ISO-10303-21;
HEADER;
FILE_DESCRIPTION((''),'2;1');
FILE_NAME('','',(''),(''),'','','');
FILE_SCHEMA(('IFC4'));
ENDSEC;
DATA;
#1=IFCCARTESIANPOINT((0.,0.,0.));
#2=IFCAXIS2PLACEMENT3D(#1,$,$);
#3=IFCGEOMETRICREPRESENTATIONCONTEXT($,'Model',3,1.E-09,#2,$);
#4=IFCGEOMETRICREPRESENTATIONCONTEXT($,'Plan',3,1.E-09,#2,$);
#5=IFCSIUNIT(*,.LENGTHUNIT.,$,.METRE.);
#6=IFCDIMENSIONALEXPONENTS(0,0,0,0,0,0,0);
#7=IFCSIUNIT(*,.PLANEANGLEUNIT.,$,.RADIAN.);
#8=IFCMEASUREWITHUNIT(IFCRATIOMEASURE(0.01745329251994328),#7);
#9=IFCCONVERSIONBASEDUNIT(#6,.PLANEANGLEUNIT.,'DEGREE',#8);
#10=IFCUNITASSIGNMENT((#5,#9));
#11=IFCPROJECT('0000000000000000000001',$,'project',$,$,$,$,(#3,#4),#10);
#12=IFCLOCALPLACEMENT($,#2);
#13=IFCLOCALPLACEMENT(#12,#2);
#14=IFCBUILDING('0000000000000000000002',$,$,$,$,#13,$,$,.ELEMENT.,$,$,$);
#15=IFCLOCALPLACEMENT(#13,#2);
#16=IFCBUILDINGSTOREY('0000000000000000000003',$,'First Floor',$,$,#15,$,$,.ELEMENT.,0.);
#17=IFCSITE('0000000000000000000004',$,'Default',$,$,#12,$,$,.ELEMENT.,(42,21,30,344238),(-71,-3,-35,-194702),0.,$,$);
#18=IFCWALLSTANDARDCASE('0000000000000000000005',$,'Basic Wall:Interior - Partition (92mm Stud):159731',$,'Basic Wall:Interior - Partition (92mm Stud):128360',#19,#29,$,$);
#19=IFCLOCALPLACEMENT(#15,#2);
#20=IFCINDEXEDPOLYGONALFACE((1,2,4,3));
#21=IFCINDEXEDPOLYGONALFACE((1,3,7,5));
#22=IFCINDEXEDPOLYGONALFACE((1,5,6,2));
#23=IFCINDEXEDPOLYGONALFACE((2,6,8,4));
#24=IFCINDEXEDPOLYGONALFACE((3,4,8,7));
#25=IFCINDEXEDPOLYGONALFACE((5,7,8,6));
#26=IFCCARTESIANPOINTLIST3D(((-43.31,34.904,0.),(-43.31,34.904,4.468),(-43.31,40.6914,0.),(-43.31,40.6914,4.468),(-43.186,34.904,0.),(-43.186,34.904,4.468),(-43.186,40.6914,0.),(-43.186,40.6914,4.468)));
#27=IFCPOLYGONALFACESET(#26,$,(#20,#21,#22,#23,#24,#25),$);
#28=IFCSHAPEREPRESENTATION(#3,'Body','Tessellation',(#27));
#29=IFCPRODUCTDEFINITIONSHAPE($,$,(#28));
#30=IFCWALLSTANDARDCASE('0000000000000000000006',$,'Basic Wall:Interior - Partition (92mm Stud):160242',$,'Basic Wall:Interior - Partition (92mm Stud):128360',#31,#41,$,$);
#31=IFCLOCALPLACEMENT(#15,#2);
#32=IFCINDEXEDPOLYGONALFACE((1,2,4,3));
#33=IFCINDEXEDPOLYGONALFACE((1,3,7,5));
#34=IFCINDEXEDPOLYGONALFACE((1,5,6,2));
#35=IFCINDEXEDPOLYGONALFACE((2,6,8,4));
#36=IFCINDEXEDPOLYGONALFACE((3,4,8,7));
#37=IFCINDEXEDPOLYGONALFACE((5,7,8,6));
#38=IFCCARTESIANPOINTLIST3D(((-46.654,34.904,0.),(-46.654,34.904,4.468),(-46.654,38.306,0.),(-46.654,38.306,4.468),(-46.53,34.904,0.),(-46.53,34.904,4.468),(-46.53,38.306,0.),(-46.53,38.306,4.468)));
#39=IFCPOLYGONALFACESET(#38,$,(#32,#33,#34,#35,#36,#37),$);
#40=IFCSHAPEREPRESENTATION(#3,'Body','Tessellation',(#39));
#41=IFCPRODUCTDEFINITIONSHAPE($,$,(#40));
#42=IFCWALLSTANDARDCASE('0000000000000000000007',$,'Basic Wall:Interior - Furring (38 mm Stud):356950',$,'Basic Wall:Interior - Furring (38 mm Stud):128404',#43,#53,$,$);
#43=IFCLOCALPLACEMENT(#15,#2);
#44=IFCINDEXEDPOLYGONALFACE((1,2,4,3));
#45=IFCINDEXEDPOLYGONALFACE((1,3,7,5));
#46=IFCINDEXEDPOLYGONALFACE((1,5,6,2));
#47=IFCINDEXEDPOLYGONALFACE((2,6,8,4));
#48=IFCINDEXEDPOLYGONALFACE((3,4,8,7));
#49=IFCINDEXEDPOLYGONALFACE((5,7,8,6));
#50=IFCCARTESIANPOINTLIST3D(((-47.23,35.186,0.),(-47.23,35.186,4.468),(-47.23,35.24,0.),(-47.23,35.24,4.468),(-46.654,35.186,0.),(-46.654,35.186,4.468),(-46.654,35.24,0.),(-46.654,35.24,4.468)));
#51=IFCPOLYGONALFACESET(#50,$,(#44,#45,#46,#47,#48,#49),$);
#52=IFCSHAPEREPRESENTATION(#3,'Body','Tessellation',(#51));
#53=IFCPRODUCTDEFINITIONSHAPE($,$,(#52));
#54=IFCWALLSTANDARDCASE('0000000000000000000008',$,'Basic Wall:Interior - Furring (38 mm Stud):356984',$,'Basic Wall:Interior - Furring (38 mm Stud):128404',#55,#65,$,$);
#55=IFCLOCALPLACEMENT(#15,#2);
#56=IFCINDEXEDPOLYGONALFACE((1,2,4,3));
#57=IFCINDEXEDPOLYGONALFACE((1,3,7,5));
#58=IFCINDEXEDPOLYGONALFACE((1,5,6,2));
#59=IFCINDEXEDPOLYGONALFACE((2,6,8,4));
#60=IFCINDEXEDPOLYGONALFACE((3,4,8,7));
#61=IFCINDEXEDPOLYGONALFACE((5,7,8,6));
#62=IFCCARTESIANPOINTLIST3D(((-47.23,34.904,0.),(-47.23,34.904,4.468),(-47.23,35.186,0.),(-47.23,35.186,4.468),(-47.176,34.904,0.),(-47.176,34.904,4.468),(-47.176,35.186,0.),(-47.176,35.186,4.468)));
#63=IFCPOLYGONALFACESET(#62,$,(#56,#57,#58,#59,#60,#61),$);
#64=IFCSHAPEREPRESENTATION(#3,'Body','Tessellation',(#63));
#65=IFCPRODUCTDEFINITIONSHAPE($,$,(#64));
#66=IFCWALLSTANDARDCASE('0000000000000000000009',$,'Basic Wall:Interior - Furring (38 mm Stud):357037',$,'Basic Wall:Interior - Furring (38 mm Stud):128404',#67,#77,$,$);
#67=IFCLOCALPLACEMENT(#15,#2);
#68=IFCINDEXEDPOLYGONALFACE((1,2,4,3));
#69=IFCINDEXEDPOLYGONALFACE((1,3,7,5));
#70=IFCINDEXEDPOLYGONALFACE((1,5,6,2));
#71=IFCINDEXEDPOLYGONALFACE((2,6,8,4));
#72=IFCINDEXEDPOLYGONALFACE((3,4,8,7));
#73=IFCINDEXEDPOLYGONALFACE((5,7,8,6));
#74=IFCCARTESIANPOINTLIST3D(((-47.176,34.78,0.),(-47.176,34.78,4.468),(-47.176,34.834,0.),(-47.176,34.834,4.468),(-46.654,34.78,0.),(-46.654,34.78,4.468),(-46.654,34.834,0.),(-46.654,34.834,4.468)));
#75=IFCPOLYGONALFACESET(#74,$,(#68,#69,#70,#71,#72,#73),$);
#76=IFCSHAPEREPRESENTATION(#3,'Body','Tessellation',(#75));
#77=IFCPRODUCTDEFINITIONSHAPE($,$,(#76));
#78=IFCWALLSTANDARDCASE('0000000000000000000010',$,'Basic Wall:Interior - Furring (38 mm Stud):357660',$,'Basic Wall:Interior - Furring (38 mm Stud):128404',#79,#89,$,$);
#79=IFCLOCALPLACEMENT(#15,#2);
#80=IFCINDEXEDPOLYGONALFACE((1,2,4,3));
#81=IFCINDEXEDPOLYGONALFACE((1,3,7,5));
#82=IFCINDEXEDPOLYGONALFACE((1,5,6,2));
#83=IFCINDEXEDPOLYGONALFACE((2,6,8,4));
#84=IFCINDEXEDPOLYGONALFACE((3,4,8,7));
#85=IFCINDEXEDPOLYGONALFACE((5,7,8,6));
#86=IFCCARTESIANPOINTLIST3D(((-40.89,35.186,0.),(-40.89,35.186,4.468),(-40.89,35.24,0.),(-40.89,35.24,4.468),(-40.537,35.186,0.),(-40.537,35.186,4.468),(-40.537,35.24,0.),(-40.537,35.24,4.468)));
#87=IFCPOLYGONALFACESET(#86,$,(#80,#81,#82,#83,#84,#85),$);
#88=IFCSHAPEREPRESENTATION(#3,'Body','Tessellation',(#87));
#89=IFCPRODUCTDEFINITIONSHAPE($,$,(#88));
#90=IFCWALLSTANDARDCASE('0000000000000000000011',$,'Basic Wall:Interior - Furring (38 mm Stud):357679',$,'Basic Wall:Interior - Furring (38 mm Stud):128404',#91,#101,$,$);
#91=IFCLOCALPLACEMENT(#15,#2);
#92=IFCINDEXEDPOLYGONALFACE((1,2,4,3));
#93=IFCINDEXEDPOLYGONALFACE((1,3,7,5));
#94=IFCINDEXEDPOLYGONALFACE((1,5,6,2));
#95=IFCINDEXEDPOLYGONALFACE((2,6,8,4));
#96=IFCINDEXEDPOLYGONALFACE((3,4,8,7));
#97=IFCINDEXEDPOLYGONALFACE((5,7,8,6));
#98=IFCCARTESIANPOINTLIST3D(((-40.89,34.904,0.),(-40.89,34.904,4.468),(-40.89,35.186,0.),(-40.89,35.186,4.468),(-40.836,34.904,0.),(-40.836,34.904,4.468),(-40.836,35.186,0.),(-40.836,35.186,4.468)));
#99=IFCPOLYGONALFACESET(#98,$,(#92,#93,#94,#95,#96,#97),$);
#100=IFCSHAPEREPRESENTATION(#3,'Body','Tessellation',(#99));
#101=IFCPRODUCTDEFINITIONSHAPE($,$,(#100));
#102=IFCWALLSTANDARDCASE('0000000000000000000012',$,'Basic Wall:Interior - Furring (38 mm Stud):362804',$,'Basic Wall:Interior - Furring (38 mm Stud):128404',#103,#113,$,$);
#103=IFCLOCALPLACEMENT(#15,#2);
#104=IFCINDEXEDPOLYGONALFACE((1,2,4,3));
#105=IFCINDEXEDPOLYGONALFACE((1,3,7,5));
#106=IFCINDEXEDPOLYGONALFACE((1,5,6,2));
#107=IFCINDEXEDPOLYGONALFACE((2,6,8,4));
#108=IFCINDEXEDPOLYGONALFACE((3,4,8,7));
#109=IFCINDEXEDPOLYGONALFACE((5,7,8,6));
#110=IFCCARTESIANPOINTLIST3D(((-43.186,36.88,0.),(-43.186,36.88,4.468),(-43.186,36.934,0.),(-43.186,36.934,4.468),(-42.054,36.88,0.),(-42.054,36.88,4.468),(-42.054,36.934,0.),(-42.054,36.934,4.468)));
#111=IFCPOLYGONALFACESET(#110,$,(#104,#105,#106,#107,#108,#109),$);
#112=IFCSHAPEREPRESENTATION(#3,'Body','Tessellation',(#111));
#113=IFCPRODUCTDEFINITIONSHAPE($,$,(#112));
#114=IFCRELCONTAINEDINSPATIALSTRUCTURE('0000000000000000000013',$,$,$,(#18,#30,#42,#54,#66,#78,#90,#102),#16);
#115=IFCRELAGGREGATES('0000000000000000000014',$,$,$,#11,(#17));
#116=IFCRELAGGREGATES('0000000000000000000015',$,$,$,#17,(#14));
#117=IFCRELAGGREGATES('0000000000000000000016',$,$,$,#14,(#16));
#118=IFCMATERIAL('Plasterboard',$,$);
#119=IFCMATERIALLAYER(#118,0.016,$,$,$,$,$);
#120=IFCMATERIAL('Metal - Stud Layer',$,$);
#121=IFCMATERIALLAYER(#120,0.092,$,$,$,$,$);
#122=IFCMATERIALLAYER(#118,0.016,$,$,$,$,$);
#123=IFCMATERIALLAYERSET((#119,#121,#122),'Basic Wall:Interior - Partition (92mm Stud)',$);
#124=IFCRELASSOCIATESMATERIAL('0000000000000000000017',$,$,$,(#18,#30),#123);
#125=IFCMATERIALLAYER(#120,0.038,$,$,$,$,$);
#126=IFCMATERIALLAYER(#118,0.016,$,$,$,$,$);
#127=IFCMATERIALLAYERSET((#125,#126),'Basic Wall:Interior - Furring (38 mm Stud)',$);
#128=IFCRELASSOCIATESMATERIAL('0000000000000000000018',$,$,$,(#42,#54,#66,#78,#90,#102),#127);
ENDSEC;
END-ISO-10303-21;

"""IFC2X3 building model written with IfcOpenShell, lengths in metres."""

from ifc_helpers import new_model, entity, si_unit, converted_unit, frame, frame_2d, origin, place, context, project, spatial, rectangle, extrude, material, layer, layer_set, layer_usage, element, save


model = new_model("IFC2X3")

# Units and contexts
model_context = context("Model", 3, precision=1e-09, world=origin())
plan_context = context("Plan", 3, precision=1e-09, world=origin())
ifc_project = project(units=[si_unit("LENGTHUNIT", "METRE"), converted_unit("PLANEANGLEUNIT", "DEGREE", entity("IfcRatioMeasure", 0.01745329251994328), si_unit("PLANEANGLEUNIT", "RADIAN"), dimensions=[0, 0, 0, 0, 0, 0, 0])], contexts=[model_context, plan_context])

# Site, building, storey
site_placement = place(None, origin())
site = spatial("IfcSite", under=ifc_project, at=site_placement, Name="Default", CompositionType="ELEMENT", RefLatitude=(42, 21, 30, 344238), RefLongitude=(-71, -3, -35, -194702), RefElevation=0.0)
building_placement = place(site_placement, origin())
building = spatial("IfcBuilding", under=site, at=building_placement, CompositionType="ELEMENT")
storey_placement = place(building_placement, origin())
storey = spatial("IfcBuildingStorey", under=building, at=storey_placement, Name="First Floor", CompositionType="ELEMENT", Elevation=0.0)

# Shared definitions
ifc_material_1 = material(Name="Plasterboard")
ifc_layer_1 = layer(ifc_material_1, 0.016)
ifc_material_2 = material(Name="Metal - Stud Layer")
ifc_layer_2 = layer(ifc_material_2, 0.092)
ifc_layer_3 = layer(ifc_material_1, 0.016)
ifc_layer_set_1 = layer_set([ifc_layer_1, ifc_layer_2, ifc_layer_3], Name="Basic Wall:Interior - Partition (92mm Stud)")

# Walls
ifc_layer_4 = layer(ifc_material_2, 0.038)
ifc_layer_5 = layer(ifc_material_1, 0.016)
ifc_layer_set_2 = layer_set([ifc_layer_4, ifc_layer_5], Name="Basic Wall:Interior - Furring (38 mm Stud)")
ifc_layer_usage_1 = layer_usage(ifc_layer_set_1, "AXIS2", "NEGATIVE", 0.062)
wall_1_placement = place(storey_placement, frame((-43.248, 34.904, 0.0), z_axis=(0.0, 0.0, 1.0), x_axis=(0.0, 1.0, 0.0)))
element("IfcWallStandardCase", 1, at=wall_1_placement, inside=storey, material=ifc_layer_usage_1, Name="Basic Wall:Interior - Partition (92mm Stud):159731", ObjectType="Basic Wall:Interior - Partition (92mm Stud):128360", context=model_context, shape_type="SweptSolid", body=[
    extrude(rectangle(XDim=5.7874, YDim=0.124, at=frame_2d((2.8937, 0.0), x_axis=(-1.0, 0.0))), origin(), (0.0, 0.0, 1.0), 4.468),
])
ifc_layer_usage_2 = layer_usage(ifc_layer_set_1, "AXIS2", "NEGATIVE", 0.062)
wall_2_placement = place(storey_placement, frame((-46.592, 38.306, 0.0), z_axis=(0.0, 0.0, 1.0), x_axis=(0.0, -1.0, 0.0)))
element("IfcWallStandardCase", 2, at=wall_2_placement, inside=storey, material=ifc_layer_usage_2, Name="Basic Wall:Interior - Partition (92mm Stud):160242", ObjectType="Basic Wall:Interior - Partition (92mm Stud):128360", context=model_context, shape_type="SweptSolid", body=[
    extrude(rectangle(XDim=3.402, YDim=0.124, at=frame_2d((1.701, 0.0), x_axis=(-1.0, 0.0))), origin(), (0.0, 0.0, 1.0), 4.468),
])
ifc_layer_usage_3 = layer_usage(ifc_layer_set_2, "AXIS2", "NEGATIVE", 0.027)
wall_3_placement = place(storey_placement, frame((-46.654, 35.213, 0.0), z_axis=(0.0, 0.0, 1.0), x_axis=(-1.0, 0.0, 0.0)))
element("IfcWallStandardCase", 3, at=wall_3_placement, inside=storey, material=ifc_layer_usage_3, Name="Basic Wall:Interior - Furring (38 mm Stud):356950", ObjectType="Basic Wall:Interior - Furring (38 mm Stud):128404", context=model_context, shape_type="SweptSolid", body=[
    extrude(rectangle(XDim=0.576, YDim=0.054, at=frame_2d((0.288, 0.0), x_axis=(-1.0, 0.0))), origin(), (0.0, 0.0, 1.0), 4.468),
])
ifc_layer_usage_4 = layer_usage(ifc_layer_set_2, "AXIS2", "NEGATIVE", 0.027)
wall_4_placement = place(storey_placement, frame((-47.203, 35.186, 0.0), z_axis=(0.0, 0.0, 1.0), x_axis=(0.0, -1.0, 0.0)))
element("IfcWallStandardCase", 4, at=wall_4_placement, inside=storey, material=ifc_layer_usage_4, Name="Basic Wall:Interior - Furring (38 mm Stud):356984", ObjectType="Basic Wall:Interior - Furring (38 mm Stud):128404", context=model_context, shape_type="SweptSolid", body=[
    extrude(rectangle(XDim=0.282, YDim=0.054, at=frame_2d((0.141, 0.0), x_axis=(-1.0, 0.0))), origin(), (0.0, 0.0, 1.0), 4.468),
])
ifc_layer_usage_5 = layer_usage(ifc_layer_set_2, "AXIS2", "NEGATIVE", 0.027)
wall_5_placement = place(storey_placement, frame((-47.176, 34.807, 0.0)))
element("IfcWallStandardCase", 5, at=wall_5_placement, inside=storey, material=ifc_layer_usage_5, Name="Basic Wall:Interior - Furring (38 mm Stud):357037", ObjectType="Basic Wall:Interior - Furring (38 mm Stud):128404", context=model_context, shape_type="SweptSolid", body=[
    extrude(rectangle(XDim=0.522, YDim=0.054, at=frame_2d((0.261, 0.0), x_axis=(-1.0, 0.0))), origin(), (0.0, 0.0, 1.0), 4.468),
])
ifc_layer_usage_6 = layer_usage(ifc_layer_set_2, "AXIS2", "NEGATIVE", 0.027)
wall_6_placement = place(storey_placement, frame((-40.537, 35.213, 0.0), z_axis=(0.0, 0.0, 1.0), x_axis=(-1.0, 0.0, 0.0)))
element("IfcWallStandardCase", 6, at=wall_6_placement, inside=storey, material=ifc_layer_usage_6, Name="Basic Wall:Interior - Furring (38 mm Stud):357660", ObjectType="Basic Wall:Interior - Furring (38 mm Stud):128404", context=model_context, shape_type="SweptSolid", body=[
    extrude(rectangle(XDim=0.353, YDim=0.054, at=frame_2d((0.1765, 0.0), x_axis=(-1.0, 0.0))), origin(), (0.0, 0.0, 1.0), 4.468),
])
ifc_layer_usage_7 = layer_usage(ifc_layer_set_2, "AXIS2", "NEGATIVE", 0.027)
wall_7_placement = place(storey_placement, frame((-40.863, 35.186, 0.0), z_axis=(0.0, 0.0, 1.0), x_axis=(0.0, -1.0, 0.0)))
element("IfcWallStandardCase", 7, at=wall_7_placement, inside=storey, material=ifc_layer_usage_7, Name="Basic Wall:Interior - Furring (38 mm Stud):357679", ObjectType="Basic Wall:Interior - Furring (38 mm Stud):128404", context=model_context, shape_type="SweptSolid", body=[
    extrude(rectangle(XDim=0.282, YDim=0.054, at=frame_2d((0.141, 0.0), x_axis=(-1.0, 0.0))), origin(), (0.0, 0.0, 1.0), 4.468),
])
ifc_layer_usage_8 = layer_usage(ifc_layer_set_2, "AXIS2", "POSITIVE", -0.027)
wall_8_placement = place(storey_placement, frame((-42.054, 36.907, 0.0), z_axis=(0.0, 0.0, 1.0), x_axis=(-1.0, 0.0, 0.0)))
element("IfcWallStandardCase", 8, at=wall_8_placement, inside=storey, material=ifc_layer_usage_8, Name="Basic Wall:Interior - Furring (38 mm Stud):362804", ObjectType="Basic Wall:Interior - Furring (38 mm Stud):128404", context=model_context, shape_type="SweptSolid", body=[
    extrude(rectangle(XDim=1.132, YDim=0.054, at=frame_2d((0.566, 0.0), x_axis=(-1.0, 0.0))), origin(), (0.0, 0.0, 1.0), 4.468),
])

save(model, "model.ifc")
